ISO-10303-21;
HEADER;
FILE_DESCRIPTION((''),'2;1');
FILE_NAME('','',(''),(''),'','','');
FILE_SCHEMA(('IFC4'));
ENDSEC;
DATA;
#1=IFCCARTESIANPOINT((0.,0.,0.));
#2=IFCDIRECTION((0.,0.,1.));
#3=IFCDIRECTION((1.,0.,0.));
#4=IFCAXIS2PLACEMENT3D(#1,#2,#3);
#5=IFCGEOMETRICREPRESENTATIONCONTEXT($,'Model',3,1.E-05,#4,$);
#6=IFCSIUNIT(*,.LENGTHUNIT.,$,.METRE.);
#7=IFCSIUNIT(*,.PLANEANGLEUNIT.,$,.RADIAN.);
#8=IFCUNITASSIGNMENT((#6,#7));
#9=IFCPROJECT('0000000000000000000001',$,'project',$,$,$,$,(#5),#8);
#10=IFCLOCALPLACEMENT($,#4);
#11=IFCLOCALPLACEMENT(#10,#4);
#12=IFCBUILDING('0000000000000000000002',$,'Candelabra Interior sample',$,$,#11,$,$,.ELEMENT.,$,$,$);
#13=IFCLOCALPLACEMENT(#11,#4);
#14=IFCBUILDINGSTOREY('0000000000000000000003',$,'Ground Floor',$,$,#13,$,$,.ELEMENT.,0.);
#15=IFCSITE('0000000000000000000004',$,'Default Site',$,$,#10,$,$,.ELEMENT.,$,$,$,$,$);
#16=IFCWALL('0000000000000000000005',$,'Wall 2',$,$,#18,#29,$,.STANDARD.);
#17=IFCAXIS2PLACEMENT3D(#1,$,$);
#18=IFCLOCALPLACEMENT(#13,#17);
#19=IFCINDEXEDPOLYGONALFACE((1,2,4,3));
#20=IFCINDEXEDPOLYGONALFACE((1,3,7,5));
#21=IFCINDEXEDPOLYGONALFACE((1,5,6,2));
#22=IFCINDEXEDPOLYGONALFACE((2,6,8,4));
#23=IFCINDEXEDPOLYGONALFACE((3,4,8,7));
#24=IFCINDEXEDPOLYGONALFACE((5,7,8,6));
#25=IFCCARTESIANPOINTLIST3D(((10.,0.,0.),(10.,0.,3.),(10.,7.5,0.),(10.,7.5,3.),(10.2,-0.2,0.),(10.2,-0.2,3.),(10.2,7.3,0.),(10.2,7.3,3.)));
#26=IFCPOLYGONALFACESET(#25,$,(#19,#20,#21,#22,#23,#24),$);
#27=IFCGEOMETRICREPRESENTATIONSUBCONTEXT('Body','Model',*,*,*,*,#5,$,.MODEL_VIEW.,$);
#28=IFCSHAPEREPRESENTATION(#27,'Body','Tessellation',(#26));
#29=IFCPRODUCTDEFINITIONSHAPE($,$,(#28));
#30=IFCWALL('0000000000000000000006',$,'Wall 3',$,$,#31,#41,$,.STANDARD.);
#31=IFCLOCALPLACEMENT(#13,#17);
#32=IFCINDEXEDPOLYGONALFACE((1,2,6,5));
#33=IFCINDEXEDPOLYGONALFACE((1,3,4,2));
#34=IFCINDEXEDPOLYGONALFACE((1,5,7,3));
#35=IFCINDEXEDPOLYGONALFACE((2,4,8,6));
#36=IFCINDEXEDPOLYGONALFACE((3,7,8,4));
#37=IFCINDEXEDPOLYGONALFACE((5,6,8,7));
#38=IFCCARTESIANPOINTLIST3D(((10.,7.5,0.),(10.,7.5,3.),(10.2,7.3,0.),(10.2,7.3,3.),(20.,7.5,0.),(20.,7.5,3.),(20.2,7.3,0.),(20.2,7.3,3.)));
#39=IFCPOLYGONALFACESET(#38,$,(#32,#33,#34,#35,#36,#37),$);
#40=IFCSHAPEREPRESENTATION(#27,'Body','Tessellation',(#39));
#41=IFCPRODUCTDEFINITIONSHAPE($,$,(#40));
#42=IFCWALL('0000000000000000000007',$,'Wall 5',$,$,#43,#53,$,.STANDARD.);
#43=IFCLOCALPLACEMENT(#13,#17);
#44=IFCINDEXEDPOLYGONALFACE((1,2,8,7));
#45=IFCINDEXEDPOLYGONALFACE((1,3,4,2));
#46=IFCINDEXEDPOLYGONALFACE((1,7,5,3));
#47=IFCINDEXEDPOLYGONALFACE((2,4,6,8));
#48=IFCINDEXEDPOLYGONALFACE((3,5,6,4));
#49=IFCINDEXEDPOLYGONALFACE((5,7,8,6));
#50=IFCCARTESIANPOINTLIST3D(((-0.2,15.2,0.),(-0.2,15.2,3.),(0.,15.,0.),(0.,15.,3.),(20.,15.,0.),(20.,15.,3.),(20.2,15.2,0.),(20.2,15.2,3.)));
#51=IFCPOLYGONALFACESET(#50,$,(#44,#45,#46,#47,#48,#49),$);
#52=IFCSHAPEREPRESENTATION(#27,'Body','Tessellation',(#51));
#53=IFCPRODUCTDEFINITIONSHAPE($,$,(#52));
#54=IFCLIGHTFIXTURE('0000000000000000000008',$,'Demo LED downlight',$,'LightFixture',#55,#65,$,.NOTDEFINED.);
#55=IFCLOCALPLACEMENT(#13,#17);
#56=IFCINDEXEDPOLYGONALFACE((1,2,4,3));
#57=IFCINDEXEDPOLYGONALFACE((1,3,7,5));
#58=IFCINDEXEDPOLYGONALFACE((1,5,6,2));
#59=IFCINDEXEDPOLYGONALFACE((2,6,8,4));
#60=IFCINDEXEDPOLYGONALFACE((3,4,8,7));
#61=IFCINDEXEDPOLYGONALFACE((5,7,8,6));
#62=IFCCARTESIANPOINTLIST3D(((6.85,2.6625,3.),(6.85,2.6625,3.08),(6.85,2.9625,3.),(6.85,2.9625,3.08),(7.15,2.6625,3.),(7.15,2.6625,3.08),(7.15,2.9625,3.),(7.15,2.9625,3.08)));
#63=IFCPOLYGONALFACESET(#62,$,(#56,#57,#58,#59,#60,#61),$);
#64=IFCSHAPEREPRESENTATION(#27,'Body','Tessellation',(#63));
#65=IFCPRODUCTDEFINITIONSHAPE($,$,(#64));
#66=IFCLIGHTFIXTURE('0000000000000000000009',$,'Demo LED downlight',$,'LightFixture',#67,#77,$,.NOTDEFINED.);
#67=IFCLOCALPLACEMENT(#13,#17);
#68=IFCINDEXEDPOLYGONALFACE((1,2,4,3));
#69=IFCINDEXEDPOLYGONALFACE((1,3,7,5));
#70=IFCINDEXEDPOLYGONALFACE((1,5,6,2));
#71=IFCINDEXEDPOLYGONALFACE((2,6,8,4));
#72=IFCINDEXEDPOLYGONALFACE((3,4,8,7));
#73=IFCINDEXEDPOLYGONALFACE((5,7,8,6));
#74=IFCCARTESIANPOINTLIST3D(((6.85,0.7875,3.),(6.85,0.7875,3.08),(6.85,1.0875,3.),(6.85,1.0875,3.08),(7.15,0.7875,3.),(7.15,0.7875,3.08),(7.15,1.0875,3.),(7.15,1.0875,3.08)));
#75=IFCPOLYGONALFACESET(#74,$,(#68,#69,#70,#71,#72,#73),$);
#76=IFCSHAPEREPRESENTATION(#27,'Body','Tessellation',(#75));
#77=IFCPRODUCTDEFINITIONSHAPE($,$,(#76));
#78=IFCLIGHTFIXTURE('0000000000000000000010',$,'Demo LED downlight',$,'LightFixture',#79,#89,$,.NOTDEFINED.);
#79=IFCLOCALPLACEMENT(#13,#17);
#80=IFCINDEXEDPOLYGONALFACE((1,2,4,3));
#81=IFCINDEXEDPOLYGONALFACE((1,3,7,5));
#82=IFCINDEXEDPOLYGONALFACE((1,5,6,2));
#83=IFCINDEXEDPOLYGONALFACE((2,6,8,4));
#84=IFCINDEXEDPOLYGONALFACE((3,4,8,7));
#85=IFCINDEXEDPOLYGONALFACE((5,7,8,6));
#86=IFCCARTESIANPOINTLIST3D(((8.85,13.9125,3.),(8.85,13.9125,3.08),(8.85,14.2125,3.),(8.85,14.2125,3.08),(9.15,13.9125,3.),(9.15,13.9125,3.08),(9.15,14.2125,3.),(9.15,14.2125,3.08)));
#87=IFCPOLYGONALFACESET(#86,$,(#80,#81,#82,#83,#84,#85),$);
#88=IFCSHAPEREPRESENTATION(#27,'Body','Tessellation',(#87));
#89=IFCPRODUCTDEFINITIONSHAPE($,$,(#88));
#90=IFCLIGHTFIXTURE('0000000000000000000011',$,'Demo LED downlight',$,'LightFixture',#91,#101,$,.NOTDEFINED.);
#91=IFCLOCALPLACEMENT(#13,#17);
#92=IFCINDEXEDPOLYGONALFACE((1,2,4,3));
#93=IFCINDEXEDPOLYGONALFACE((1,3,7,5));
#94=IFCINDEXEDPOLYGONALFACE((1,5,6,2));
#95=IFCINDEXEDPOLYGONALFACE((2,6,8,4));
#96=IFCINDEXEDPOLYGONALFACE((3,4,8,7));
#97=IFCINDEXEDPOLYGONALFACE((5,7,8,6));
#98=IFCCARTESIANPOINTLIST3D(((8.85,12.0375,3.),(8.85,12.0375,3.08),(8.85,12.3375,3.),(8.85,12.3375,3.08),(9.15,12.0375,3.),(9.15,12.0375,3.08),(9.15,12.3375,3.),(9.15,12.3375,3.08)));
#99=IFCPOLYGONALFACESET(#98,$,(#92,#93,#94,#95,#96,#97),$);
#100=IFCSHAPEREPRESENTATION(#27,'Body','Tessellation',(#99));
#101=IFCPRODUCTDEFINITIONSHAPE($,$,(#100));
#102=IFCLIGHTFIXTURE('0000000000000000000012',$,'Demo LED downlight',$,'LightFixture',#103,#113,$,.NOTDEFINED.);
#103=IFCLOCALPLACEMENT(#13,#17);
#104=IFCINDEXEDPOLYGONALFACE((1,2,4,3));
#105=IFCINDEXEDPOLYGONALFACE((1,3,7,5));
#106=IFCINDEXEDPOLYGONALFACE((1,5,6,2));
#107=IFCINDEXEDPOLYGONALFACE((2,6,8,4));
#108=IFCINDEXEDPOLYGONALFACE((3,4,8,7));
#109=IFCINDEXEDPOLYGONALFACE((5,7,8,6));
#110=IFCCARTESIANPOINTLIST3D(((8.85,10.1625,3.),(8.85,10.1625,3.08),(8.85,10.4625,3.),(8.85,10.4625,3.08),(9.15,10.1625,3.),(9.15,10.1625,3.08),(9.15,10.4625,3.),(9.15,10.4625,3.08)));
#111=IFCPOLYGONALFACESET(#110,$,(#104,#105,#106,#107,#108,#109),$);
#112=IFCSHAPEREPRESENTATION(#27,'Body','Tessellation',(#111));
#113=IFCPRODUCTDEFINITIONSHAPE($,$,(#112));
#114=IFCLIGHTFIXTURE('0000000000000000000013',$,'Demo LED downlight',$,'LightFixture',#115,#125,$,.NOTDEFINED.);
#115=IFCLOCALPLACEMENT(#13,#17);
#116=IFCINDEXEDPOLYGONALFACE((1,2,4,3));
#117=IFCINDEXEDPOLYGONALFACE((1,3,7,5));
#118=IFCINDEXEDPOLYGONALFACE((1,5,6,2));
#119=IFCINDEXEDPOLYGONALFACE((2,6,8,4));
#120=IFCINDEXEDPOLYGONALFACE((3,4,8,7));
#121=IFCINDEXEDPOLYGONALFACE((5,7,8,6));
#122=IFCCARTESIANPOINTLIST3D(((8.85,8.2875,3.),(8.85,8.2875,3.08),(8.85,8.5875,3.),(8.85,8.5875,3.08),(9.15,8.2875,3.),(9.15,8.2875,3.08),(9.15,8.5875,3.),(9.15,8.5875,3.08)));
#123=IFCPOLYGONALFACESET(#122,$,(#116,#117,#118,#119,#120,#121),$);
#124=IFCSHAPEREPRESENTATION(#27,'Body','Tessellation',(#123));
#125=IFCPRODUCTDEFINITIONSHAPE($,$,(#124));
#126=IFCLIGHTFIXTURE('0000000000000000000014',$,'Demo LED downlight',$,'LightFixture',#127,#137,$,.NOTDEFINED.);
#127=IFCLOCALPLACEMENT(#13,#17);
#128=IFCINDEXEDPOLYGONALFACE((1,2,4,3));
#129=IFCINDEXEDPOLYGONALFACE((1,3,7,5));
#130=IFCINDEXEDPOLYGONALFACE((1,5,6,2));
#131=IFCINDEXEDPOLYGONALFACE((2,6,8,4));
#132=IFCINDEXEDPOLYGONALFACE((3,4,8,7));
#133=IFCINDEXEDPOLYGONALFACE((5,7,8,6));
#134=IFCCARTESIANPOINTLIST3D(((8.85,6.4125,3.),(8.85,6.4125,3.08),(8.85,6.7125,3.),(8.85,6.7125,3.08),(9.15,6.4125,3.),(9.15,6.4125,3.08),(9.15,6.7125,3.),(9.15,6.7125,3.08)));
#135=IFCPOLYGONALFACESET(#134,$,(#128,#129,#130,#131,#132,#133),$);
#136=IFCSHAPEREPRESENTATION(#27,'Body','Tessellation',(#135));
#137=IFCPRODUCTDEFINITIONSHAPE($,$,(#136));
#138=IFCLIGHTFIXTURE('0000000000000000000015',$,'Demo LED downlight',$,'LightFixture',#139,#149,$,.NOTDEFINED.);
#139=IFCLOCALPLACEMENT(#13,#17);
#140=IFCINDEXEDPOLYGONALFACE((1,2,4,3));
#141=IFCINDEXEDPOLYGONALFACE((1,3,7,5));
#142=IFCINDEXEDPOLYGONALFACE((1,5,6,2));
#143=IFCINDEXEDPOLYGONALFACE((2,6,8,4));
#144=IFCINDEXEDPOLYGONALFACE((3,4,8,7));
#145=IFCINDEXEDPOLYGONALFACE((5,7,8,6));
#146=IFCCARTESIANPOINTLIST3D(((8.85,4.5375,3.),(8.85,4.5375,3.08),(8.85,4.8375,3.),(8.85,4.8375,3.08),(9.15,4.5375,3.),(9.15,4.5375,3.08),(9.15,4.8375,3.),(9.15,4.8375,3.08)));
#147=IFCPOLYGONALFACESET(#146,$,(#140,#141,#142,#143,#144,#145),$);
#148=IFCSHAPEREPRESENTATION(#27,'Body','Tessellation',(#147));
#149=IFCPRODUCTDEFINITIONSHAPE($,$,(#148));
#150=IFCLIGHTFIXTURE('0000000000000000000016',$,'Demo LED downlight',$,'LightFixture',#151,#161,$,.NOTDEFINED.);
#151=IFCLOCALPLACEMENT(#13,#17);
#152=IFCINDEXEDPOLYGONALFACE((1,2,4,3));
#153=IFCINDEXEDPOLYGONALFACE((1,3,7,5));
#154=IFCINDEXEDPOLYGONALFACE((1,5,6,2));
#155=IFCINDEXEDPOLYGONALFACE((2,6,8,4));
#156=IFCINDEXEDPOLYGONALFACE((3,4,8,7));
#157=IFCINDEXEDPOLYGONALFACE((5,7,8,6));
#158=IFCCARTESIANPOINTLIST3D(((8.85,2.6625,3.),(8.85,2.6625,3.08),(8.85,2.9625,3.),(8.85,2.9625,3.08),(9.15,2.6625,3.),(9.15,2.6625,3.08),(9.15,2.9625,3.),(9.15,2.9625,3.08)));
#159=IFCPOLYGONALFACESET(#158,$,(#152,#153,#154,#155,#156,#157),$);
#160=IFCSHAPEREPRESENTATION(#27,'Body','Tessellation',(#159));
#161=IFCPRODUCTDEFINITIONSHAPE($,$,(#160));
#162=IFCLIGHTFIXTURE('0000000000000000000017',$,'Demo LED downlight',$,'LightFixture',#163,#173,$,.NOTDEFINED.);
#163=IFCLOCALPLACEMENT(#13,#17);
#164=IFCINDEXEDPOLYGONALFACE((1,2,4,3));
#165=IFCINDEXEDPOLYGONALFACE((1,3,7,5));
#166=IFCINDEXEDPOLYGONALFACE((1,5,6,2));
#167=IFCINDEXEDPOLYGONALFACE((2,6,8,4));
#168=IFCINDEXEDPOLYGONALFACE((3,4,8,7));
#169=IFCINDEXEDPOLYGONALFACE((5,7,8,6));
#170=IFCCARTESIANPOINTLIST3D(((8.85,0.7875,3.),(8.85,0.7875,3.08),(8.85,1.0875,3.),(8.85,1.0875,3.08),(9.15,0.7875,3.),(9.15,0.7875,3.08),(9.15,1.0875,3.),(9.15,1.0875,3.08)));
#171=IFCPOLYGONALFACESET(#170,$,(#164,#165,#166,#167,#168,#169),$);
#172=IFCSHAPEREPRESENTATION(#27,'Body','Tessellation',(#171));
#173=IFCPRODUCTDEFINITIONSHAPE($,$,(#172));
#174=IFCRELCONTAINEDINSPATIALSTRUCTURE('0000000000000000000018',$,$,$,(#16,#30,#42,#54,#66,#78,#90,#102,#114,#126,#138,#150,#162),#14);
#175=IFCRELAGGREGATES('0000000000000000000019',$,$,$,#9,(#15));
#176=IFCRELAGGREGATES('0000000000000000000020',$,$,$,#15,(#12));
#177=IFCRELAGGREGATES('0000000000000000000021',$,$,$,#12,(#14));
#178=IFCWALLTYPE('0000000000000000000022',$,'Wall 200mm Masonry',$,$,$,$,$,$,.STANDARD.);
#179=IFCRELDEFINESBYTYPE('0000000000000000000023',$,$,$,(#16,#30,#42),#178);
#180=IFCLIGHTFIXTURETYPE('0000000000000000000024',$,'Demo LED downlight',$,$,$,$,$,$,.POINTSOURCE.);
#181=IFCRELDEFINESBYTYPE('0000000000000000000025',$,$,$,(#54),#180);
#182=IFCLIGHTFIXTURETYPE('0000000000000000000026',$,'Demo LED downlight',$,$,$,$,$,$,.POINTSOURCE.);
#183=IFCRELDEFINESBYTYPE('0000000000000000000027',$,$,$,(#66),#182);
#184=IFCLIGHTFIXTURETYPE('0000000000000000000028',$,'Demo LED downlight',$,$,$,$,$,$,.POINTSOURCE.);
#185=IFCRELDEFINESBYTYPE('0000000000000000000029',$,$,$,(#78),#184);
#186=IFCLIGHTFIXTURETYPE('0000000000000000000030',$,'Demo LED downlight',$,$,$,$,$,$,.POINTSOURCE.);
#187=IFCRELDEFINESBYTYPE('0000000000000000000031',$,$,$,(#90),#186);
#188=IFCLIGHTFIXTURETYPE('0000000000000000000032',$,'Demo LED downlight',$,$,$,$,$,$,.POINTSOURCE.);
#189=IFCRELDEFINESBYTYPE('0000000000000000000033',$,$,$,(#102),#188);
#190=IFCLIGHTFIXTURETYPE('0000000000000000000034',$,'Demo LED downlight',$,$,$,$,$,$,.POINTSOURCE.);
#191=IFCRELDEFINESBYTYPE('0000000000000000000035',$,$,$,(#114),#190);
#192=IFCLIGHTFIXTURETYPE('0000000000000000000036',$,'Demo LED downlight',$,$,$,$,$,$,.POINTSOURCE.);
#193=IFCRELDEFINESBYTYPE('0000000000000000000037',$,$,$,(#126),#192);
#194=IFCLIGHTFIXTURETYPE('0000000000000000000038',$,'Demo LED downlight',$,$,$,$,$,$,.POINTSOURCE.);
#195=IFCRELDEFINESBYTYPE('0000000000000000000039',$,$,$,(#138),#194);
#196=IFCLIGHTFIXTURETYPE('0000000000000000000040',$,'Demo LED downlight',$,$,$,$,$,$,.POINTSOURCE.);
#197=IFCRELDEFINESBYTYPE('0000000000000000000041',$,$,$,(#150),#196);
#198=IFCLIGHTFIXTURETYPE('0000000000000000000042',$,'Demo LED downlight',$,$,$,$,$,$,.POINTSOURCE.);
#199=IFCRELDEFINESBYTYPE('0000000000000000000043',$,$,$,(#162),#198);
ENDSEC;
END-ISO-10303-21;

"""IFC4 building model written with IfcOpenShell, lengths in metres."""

from ifc_helpers import new_model, si_unit, frame, origin_with_axes, place, context, subcontext, project, spatial, polyline, outline, extrude, type_object, element, save


model = new_model("IFC4")

# Units and contexts
model_context = context("Model", 3, precision=1e-05, world=origin_with_axes())
body_context = subcontext(model_context, "Body", "Model", "MODEL_VIEW")
ifc_project = project(units=[si_unit("LENGTHUNIT", "METRE"), si_unit("PLANEANGLEUNIT", "RADIAN")], contexts=[model_context])

# Site, building, storey
site_placement = place(None, origin_with_axes())
site = spatial("IfcSite", under=ifc_project, at=site_placement, Name="Default Site", CompositionType="ELEMENT")
building_placement = place(site_placement, origin_with_axes())
building = spatial("IfcBuilding", under=site, at=building_placement, Name="Candelabra Interior sample", CompositionType="ELEMENT")
storey_placement = place(building_placement, origin_with_axes())
storey = spatial("IfcBuildingStorey", under=building, at=storey_placement, Name="Ground Floor", CompositionType="ELEMENT", Elevation=0.0)

# Walls
wall_type = type_object("IfcWallType", Name="Wall 200mm Masonry", PredefinedType="STANDARD")
wall_1_placement = place(storey_placement, frame((10.1, 3.65, 0.0), z_axis=(0.0, 0.0, 1.0), x_axis=(0.0, 1.0, 0.0)))
element("IfcWall", 1, at=wall_1_placement, inside=storey, type_object=wall_type, Name="Wall 2", PredefinedType="STANDARD", context=body_context, shape_type="SweptSolid", body=[
    extrude(outline(polyline([(3.85, 0.1), (-3.65, 0.1), (-3.85, -0.1), (3.65, -0.1), (3.85, 0.1)])), origin_with_axes(), (0.0, 0.0, 1.0), 3.0),
])
wall_2_placement = place(storey_placement, frame((15.1, 7.4, 0.0), z_axis=(0.0, 0.0, 1.0), x_axis=(1.0, 0.0, 0.0)))
element("IfcWall", 2, at=wall_2_placement, inside=storey, type_object=wall_type, Name="Wall 3", PredefinedType="STANDARD", context=body_context, shape_type="SweptSolid", body=[
    extrude(outline(polyline([(4.9, 0.1), (-5.1, 0.1), (-4.9, -0.1), (5.1, -0.1), (4.9, 0.1)])), origin_with_axes(), (0.0, 0.0, 1.0), 3.0),
])
wall_3_placement = place(storey_placement, frame((10.0, 15.1, 0.0), z_axis=(0.0, 0.0, 1.0), x_axis=(-1.0, 0.0, 0.0)))
element("IfcWall", 3, at=wall_3_placement, inside=storey, type_object=wall_type, Name="Wall 5", PredefinedType="STANDARD", context=body_context, shape_type="SweptSolid", body=[
    extrude(outline(polyline([(10.0, 0.1), (-10.0, 0.1), (-10.2, -0.1), (10.2, -0.1), (10.0, 0.1)])), origin_with_axes(), (0.0, 0.0, 1.0), 3.0),
])

# Light fixtures
light_fixture_type_1 = type_object("IfcLightFixtureType", Name="Demo LED downlight", PredefinedType="POINTSOURCE")
light_fixture_1_placement = place(storey_placement, frame((7.0, 2.8125, 3.08), z_axis=(0.0, 0.0, 1.0), x_axis=(1.0, 0.0, 0.0)))
element("IfcLightFixture", 4, at=light_fixture_1_placement, inside=storey, type_object=light_fixture_type_1, Name="Demo LED downlight", ObjectType="LightFixture", PredefinedType="NOTDEFINED", context=body_context, shape_type="SweptSolid", body=[
    extrude(outline(polyline([(0.15, 0.15), (-0.15, 0.15), (-0.15, -0.15), (0.15, -0.15), (0.15, 0.15)])), origin_with_axes(), (0.0, 0.0, -1.0), 0.08),
])
light_fixture_type_2 = type_object("IfcLightFixtureType", Name="Demo LED downlight", PredefinedType="POINTSOURCE")
light_fixture_2_placement = place(storey_placement, frame((7.0, 0.9375, 3.08), z_axis=(0.0, 0.0, 1.0), x_axis=(1.0, 0.0, 0.0)))
element("IfcLightFixture", 5, at=light_fixture_2_placement, inside=storey, type_object=light_fixture_type_2, Name="Demo LED downlight", ObjectType="LightFixture", PredefinedType="NOTDEFINED", context=body_context, shape_type="SweptSolid", body=[
    extrude(outline(polyline([(0.15, 0.15), (-0.15, 0.15), (-0.15, -0.15), (0.15, -0.15), (0.15, 0.15)])), origin_with_axes(), (0.0, 0.0, -1.0), 0.08),
])
light_fixture_type_3 = type_object("IfcLightFixtureType", Name="Demo LED downlight", PredefinedType="POINTSOURCE")
light_fixture_3_placement = place(storey_placement, frame((9.0, 14.0625, 3.08), z_axis=(0.0, 0.0, 1.0), x_axis=(1.0, 0.0, 0.0)))
element("IfcLightFixture", 6, at=light_fixture_3_placement, inside=storey, type_object=light_fixture_type_3, Name="Demo LED downlight", ObjectType="LightFixture", PredefinedType="NOTDEFINED", context=body_context, shape_type="SweptSolid", body=[
    extrude(outline(polyline([(0.15, 0.15), (-0.15, 0.15), (-0.15, -0.15), (0.15, -0.15), (0.15, 0.15)])), origin_with_axes(), (0.0, 0.0, -1.0), 0.08),
])
light_fixture_type_4 = type_object("IfcLightFixtureType", Name="Demo LED downlight", PredefinedType="POINTSOURCE")
light_fixture_4_placement = place(storey_placement, frame((9.0, 12.1875, 3.08), z_axis=(0.0, 0.0, 1.0), x_axis=(1.0, 0.0, 0.0)))
element("IfcLightFixture", 7, at=light_fixture_4_placement, inside=storey, type_object=light_fixture_type_4, Name="Demo LED downlight", ObjectType="LightFixture", PredefinedType="NOTDEFINED", context=body_context, shape_type="SweptSolid", body=[
    extrude(outline(polyline([(0.15, 0.15), (-0.15, 0.15), (-0.15, -0.15), (0.15, -0.15), (0.15, 0.15)])), origin_with_axes(), (0.0, 0.0, -1.0), 0.08),
])
light_fixture_type_5 = type_object("IfcLightFixtureType", Name="Demo LED downlight", PredefinedType="POINTSOURCE")
light_fixture_5_placement = place(storey_placement, frame((9.0, 10.3125, 3.08), z_axis=(0.0, 0.0, 1.0), x_axis=(1.0, 0.0, 0.0)))
element("IfcLightFixture", 8, at=light_fixture_5_placement, inside=storey, type_object=light_fixture_type_5, Name="Demo LED downlight", ObjectType="LightFixture", PredefinedType="NOTDEFINED", context=body_context, shape_type="SweptSolid", body=[
    extrude(outline(polyline([(0.15, 0.15), (-0.15, 0.15), (-0.15, -0.15), (0.15, -0.15), (0.15, 0.15)])), origin_with_axes(), (0.0, 0.0, -1.0), 0.08),
])
light_fixture_type_6 = type_object("IfcLightFixtureType", Name="Demo LED downlight", PredefinedType="POINTSOURCE")
light_fixture_6_placement = place(storey_placement, frame((9.0, 8.4375, 3.08), z_axis=(0.0, 0.0, 1.0), x_axis=(1.0, 0.0, 0.0)))
element("IfcLightFixture", 9, at=light_fixture_6_placement, inside=storey, type_object=light_fixture_type_6, Name="Demo LED downlight", ObjectType="LightFixture", PredefinedType="NOTDEFINED", context=body_context, shape_type="SweptSolid", body=[
    extrude(outline(polyline([(0.15, 0.15), (-0.15, 0.15), (-0.15, -0.15), (0.15, -0.15), (0.15, 0.15)])), origin_with_axes(), (0.0, 0.0, -1.0), 0.08),
])
light_fixture_type_7 = type_object("IfcLightFixtureType", Name="Demo LED downlight", PredefinedType="POINTSOURCE")
light_fixture_7_placement = place(storey_placement, frame((9.0, 6.5625, 3.08), z_axis=(0.0, 0.0, 1.0), x_axis=(1.0, 0.0, 0.0)))
element("IfcLightFixture", 10, at=light_fixture_7_placement, inside=storey, type_object=light_fixture_type_7, Name="Demo LED downlight", ObjectType="LightFixture", PredefinedType="NOTDEFINED", context=body_context, shape_type="SweptSolid", body=[
    extrude(outline(polyline([(0.15, 0.15), (-0.15, 0.15), (-0.15, -0.15), (0.15, -0.15), (0.15, 0.15)])), origin_with_axes(), (0.0, 0.0, -1.0), 0.08),
])
light_fixture_type_8 = type_object("IfcLightFixtureType", Name="Demo LED downlight", PredefinedType="POINTSOURCE")
light_fixture_8_placement = place(storey_placement, frame((9.0, 4.6875, 3.08), z_axis=(0.0, 0.0, 1.0), x_axis=(1.0, 0.0, 0.0)))
element("IfcLightFixture", 11, at=light_fixture_8_placement, inside=storey, type_object=light_fixture_type_8, Name="Demo LED downlight", ObjectType="LightFixture", PredefinedType="NOTDEFINED", context=body_context, shape_type="SweptSolid", body=[
    extrude(outline(polyline([(0.15, 0.15), (-0.15, 0.15), (-0.15, -0.15), (0.15, -0.15), (0.15, 0.15)])), origin_with_axes(), (0.0, 0.0, -1.0), 0.08),
])
light_fixture_type_9 = type_object("IfcLightFixtureType", Name="Demo LED downlight", PredefinedType="POINTSOURCE")
light_fixture_9_placement = place(storey_placement, frame((9.0, 2.8125, 3.08), z_axis=(0.0, 0.0, 1.0), x_axis=(1.0, 0.0, 0.0)))
element("IfcLightFixture", 12, at=light_fixture_9_placement, inside=storey, type_object=light_fixture_type_9, Name="Demo LED downlight", ObjectType="LightFixture", PredefinedType="NOTDEFINED", context=body_context, shape_type="SweptSolid", body=[
    extrude(outline(polyline([(0.15, 0.15), (-0.15, 0.15), (-0.15, -0.15), (0.15, -0.15), (0.15, 0.15)])), origin_with_axes(), (0.0, 0.0, -1.0), 0.08),
])
light_fixture_type_10 = type_object("IfcLightFixtureType", Name="Demo LED downlight", PredefinedType="POINTSOURCE")
light_fixture_10_placement = place(storey_placement, frame((9.0, 0.9375, 3.08), z_axis=(0.0, 0.0, 1.0), x_axis=(1.0, 0.0, 0.0)))
element("IfcLightFixture", 13, at=light_fixture_10_placement, inside=storey, type_object=light_fixture_type_10, Name="Demo LED downlight", ObjectType="LightFixture", PredefinedType="NOTDEFINED", context=body_context, shape_type="SweptSolid", body=[
    extrude(outline(polyline([(0.15, 0.15), (-0.15, 0.15), (-0.15, -0.15), (0.15, -0.15), (0.15, 0.15)])), origin_with_axes(), (0.0, 0.0, -1.0), 0.08),
])

save(model, "model.ifc")
